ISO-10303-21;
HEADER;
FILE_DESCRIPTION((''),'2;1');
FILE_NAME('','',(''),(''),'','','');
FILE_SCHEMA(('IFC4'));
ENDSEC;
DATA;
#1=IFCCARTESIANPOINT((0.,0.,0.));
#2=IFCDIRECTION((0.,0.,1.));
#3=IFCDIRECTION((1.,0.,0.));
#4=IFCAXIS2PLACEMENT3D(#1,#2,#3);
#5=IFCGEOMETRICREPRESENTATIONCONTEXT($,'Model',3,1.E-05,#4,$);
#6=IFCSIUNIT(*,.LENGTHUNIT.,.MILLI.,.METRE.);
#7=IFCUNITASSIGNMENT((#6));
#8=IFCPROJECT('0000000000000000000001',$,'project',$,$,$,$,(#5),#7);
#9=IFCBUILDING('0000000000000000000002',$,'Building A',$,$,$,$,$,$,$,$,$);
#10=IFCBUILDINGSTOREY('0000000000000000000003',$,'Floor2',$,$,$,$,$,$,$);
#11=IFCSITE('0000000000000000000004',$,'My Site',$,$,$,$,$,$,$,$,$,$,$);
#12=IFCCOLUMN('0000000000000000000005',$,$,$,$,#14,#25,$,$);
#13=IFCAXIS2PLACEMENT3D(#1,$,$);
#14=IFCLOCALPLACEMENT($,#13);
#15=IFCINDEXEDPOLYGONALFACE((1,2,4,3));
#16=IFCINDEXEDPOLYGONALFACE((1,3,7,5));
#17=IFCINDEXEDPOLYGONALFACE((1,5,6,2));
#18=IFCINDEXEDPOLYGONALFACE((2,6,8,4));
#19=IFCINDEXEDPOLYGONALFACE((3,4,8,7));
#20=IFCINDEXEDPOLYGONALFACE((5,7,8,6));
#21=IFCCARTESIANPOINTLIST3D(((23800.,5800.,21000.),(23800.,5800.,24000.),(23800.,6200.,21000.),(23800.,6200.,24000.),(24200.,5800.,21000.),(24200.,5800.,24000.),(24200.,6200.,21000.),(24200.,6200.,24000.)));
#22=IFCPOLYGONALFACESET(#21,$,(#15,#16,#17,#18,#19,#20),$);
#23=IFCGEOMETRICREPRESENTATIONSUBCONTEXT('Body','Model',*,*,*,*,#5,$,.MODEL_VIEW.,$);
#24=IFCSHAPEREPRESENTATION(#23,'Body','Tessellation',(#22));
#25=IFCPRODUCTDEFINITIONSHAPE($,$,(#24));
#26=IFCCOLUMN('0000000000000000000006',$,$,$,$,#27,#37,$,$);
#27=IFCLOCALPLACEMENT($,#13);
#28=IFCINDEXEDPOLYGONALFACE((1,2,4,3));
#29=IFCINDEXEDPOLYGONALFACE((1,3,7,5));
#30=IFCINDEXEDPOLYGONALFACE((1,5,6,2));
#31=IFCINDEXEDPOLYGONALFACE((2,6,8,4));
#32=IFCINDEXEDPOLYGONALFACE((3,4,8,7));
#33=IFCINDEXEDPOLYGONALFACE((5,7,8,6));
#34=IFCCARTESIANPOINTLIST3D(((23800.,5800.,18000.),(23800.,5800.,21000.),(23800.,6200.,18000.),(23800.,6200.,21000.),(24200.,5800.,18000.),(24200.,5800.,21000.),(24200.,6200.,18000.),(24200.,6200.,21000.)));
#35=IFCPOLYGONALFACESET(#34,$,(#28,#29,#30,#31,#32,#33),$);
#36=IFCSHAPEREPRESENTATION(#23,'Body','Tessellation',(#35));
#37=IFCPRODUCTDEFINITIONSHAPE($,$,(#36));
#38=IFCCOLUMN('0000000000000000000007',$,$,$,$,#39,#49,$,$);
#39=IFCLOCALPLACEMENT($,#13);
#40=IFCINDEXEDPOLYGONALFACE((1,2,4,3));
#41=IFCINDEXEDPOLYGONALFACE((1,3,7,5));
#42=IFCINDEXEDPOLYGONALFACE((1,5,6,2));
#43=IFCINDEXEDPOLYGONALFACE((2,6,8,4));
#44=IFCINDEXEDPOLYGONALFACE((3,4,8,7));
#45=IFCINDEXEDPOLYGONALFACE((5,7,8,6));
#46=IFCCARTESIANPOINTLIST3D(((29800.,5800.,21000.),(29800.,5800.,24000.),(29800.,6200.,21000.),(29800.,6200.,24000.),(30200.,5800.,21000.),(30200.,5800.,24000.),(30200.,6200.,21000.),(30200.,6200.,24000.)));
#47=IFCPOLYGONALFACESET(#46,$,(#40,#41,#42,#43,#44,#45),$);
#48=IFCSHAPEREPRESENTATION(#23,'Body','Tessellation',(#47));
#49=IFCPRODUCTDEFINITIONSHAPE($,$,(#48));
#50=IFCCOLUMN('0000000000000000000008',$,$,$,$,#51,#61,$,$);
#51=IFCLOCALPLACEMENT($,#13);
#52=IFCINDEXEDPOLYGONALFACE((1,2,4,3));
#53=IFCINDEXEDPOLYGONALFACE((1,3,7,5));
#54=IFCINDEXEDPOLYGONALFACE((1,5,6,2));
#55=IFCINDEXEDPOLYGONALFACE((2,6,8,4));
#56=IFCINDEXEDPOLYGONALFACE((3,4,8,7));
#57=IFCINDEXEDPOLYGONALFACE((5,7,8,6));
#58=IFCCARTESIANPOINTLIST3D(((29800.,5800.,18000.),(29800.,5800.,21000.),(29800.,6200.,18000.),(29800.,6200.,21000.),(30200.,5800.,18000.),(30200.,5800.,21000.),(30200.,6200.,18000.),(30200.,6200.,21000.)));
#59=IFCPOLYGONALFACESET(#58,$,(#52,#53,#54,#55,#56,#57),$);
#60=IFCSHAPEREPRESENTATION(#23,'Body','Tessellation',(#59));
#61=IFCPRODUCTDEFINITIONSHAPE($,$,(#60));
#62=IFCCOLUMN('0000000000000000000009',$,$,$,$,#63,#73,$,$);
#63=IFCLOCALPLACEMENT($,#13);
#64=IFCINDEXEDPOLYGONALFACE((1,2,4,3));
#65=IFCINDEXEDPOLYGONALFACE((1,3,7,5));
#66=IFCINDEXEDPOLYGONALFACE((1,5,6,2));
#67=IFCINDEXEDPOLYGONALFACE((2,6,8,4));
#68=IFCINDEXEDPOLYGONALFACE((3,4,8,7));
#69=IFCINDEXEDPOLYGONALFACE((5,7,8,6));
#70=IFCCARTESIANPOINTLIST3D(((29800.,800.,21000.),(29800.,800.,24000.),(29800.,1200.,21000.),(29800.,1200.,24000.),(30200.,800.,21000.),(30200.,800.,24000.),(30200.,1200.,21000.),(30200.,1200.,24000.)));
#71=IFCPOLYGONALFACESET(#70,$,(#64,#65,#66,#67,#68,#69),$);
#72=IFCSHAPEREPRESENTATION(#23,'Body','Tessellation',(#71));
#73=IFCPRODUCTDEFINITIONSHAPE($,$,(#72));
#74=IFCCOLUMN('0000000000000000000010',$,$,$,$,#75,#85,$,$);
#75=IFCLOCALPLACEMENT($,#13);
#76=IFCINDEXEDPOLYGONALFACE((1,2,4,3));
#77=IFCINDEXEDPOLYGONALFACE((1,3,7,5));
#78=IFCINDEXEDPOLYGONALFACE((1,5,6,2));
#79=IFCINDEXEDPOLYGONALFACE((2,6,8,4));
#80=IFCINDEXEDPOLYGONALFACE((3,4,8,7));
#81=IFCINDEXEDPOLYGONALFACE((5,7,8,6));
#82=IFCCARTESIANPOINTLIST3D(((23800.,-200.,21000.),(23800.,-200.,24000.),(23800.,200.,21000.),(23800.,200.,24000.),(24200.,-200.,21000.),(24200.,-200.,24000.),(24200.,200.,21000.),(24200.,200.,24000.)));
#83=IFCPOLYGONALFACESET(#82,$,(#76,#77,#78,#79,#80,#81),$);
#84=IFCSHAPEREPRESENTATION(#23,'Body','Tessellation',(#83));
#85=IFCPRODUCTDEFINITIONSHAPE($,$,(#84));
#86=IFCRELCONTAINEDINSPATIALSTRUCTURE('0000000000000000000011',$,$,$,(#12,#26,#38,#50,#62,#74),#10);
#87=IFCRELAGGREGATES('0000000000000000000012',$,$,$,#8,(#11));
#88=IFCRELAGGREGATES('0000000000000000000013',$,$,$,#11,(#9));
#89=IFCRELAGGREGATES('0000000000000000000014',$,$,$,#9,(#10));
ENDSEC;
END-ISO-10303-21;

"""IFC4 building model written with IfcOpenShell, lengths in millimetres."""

from ifc_helpers import new_model, si_unit, frame, origin_with_axes, place, context, subcontext, project, spatial, line, indexed_curve, outline, extrude, element, save


model = new_model("IFC4")

# Units and contexts
model_context = context("Model", 3, precision=1e-05, world=origin_with_axes())
body_context = subcontext(model_context, "Body", "Model", "MODEL_VIEW")
ifc_project = project(units=[si_unit("LENGTHUNIT", "METRE", prefix="MILLI")], contexts=[model_context])

# Site, building, storey
site = spatial("IfcSite", under=ifc_project, Name="My Site")
building = spatial("IfcBuilding", under=site, Name="Building A")
storey = spatial("IfcBuildingStorey", under=building, Name="Floor2")

# Columns
for number, where, z_axis, x_axis in (
    (1, (24000.0, 6000.0, 21000.0), (0.0, 0.0, 1.0), (1.0, 0.0, 0.0)),
    (2, (24000.0, 6000.0, 18000.0), (0.0, 0.0, 1.0), (1.0, 0.0, 0.0)),
    (3, (30000.0, 6000.0, 21000.0), (0.0, 0.0, 1.0), (1.0, 0.0, 0.0)),
    (4, (30000.0, 6000.0, 18000.0), (0.0, 0.0, 1.0), (1.0, 0.0, 0.0)),
    (5, (30000.0, 1000.0, 21000.0), (0.0, 0.0, 1.0), (1.0, 0.0, 0.0)),
    (6, (24000.0, 0.0, 21000.0), (0.0, 0.0, 1.0), (1.0, 0.0, 0.0)),
):
    element("IfcColumn", number, at=place(None, frame(where, z_axis=z_axis, x_axis=x_axis)), inside=storey, context=body_context, shape_type="SweptSolid", body=[
        extrude(outline(indexed_curve([(-200.0, -200.0), (200.0, -200.0), (200.0, 200.0), (-200.0, 200.0)], segments=[line(1, 2, 3, 4, 1)])), origin_with_axes(), (0.0, 0.0, 1.0), 3000.0),
    ])

save(model, "model.ifc")
